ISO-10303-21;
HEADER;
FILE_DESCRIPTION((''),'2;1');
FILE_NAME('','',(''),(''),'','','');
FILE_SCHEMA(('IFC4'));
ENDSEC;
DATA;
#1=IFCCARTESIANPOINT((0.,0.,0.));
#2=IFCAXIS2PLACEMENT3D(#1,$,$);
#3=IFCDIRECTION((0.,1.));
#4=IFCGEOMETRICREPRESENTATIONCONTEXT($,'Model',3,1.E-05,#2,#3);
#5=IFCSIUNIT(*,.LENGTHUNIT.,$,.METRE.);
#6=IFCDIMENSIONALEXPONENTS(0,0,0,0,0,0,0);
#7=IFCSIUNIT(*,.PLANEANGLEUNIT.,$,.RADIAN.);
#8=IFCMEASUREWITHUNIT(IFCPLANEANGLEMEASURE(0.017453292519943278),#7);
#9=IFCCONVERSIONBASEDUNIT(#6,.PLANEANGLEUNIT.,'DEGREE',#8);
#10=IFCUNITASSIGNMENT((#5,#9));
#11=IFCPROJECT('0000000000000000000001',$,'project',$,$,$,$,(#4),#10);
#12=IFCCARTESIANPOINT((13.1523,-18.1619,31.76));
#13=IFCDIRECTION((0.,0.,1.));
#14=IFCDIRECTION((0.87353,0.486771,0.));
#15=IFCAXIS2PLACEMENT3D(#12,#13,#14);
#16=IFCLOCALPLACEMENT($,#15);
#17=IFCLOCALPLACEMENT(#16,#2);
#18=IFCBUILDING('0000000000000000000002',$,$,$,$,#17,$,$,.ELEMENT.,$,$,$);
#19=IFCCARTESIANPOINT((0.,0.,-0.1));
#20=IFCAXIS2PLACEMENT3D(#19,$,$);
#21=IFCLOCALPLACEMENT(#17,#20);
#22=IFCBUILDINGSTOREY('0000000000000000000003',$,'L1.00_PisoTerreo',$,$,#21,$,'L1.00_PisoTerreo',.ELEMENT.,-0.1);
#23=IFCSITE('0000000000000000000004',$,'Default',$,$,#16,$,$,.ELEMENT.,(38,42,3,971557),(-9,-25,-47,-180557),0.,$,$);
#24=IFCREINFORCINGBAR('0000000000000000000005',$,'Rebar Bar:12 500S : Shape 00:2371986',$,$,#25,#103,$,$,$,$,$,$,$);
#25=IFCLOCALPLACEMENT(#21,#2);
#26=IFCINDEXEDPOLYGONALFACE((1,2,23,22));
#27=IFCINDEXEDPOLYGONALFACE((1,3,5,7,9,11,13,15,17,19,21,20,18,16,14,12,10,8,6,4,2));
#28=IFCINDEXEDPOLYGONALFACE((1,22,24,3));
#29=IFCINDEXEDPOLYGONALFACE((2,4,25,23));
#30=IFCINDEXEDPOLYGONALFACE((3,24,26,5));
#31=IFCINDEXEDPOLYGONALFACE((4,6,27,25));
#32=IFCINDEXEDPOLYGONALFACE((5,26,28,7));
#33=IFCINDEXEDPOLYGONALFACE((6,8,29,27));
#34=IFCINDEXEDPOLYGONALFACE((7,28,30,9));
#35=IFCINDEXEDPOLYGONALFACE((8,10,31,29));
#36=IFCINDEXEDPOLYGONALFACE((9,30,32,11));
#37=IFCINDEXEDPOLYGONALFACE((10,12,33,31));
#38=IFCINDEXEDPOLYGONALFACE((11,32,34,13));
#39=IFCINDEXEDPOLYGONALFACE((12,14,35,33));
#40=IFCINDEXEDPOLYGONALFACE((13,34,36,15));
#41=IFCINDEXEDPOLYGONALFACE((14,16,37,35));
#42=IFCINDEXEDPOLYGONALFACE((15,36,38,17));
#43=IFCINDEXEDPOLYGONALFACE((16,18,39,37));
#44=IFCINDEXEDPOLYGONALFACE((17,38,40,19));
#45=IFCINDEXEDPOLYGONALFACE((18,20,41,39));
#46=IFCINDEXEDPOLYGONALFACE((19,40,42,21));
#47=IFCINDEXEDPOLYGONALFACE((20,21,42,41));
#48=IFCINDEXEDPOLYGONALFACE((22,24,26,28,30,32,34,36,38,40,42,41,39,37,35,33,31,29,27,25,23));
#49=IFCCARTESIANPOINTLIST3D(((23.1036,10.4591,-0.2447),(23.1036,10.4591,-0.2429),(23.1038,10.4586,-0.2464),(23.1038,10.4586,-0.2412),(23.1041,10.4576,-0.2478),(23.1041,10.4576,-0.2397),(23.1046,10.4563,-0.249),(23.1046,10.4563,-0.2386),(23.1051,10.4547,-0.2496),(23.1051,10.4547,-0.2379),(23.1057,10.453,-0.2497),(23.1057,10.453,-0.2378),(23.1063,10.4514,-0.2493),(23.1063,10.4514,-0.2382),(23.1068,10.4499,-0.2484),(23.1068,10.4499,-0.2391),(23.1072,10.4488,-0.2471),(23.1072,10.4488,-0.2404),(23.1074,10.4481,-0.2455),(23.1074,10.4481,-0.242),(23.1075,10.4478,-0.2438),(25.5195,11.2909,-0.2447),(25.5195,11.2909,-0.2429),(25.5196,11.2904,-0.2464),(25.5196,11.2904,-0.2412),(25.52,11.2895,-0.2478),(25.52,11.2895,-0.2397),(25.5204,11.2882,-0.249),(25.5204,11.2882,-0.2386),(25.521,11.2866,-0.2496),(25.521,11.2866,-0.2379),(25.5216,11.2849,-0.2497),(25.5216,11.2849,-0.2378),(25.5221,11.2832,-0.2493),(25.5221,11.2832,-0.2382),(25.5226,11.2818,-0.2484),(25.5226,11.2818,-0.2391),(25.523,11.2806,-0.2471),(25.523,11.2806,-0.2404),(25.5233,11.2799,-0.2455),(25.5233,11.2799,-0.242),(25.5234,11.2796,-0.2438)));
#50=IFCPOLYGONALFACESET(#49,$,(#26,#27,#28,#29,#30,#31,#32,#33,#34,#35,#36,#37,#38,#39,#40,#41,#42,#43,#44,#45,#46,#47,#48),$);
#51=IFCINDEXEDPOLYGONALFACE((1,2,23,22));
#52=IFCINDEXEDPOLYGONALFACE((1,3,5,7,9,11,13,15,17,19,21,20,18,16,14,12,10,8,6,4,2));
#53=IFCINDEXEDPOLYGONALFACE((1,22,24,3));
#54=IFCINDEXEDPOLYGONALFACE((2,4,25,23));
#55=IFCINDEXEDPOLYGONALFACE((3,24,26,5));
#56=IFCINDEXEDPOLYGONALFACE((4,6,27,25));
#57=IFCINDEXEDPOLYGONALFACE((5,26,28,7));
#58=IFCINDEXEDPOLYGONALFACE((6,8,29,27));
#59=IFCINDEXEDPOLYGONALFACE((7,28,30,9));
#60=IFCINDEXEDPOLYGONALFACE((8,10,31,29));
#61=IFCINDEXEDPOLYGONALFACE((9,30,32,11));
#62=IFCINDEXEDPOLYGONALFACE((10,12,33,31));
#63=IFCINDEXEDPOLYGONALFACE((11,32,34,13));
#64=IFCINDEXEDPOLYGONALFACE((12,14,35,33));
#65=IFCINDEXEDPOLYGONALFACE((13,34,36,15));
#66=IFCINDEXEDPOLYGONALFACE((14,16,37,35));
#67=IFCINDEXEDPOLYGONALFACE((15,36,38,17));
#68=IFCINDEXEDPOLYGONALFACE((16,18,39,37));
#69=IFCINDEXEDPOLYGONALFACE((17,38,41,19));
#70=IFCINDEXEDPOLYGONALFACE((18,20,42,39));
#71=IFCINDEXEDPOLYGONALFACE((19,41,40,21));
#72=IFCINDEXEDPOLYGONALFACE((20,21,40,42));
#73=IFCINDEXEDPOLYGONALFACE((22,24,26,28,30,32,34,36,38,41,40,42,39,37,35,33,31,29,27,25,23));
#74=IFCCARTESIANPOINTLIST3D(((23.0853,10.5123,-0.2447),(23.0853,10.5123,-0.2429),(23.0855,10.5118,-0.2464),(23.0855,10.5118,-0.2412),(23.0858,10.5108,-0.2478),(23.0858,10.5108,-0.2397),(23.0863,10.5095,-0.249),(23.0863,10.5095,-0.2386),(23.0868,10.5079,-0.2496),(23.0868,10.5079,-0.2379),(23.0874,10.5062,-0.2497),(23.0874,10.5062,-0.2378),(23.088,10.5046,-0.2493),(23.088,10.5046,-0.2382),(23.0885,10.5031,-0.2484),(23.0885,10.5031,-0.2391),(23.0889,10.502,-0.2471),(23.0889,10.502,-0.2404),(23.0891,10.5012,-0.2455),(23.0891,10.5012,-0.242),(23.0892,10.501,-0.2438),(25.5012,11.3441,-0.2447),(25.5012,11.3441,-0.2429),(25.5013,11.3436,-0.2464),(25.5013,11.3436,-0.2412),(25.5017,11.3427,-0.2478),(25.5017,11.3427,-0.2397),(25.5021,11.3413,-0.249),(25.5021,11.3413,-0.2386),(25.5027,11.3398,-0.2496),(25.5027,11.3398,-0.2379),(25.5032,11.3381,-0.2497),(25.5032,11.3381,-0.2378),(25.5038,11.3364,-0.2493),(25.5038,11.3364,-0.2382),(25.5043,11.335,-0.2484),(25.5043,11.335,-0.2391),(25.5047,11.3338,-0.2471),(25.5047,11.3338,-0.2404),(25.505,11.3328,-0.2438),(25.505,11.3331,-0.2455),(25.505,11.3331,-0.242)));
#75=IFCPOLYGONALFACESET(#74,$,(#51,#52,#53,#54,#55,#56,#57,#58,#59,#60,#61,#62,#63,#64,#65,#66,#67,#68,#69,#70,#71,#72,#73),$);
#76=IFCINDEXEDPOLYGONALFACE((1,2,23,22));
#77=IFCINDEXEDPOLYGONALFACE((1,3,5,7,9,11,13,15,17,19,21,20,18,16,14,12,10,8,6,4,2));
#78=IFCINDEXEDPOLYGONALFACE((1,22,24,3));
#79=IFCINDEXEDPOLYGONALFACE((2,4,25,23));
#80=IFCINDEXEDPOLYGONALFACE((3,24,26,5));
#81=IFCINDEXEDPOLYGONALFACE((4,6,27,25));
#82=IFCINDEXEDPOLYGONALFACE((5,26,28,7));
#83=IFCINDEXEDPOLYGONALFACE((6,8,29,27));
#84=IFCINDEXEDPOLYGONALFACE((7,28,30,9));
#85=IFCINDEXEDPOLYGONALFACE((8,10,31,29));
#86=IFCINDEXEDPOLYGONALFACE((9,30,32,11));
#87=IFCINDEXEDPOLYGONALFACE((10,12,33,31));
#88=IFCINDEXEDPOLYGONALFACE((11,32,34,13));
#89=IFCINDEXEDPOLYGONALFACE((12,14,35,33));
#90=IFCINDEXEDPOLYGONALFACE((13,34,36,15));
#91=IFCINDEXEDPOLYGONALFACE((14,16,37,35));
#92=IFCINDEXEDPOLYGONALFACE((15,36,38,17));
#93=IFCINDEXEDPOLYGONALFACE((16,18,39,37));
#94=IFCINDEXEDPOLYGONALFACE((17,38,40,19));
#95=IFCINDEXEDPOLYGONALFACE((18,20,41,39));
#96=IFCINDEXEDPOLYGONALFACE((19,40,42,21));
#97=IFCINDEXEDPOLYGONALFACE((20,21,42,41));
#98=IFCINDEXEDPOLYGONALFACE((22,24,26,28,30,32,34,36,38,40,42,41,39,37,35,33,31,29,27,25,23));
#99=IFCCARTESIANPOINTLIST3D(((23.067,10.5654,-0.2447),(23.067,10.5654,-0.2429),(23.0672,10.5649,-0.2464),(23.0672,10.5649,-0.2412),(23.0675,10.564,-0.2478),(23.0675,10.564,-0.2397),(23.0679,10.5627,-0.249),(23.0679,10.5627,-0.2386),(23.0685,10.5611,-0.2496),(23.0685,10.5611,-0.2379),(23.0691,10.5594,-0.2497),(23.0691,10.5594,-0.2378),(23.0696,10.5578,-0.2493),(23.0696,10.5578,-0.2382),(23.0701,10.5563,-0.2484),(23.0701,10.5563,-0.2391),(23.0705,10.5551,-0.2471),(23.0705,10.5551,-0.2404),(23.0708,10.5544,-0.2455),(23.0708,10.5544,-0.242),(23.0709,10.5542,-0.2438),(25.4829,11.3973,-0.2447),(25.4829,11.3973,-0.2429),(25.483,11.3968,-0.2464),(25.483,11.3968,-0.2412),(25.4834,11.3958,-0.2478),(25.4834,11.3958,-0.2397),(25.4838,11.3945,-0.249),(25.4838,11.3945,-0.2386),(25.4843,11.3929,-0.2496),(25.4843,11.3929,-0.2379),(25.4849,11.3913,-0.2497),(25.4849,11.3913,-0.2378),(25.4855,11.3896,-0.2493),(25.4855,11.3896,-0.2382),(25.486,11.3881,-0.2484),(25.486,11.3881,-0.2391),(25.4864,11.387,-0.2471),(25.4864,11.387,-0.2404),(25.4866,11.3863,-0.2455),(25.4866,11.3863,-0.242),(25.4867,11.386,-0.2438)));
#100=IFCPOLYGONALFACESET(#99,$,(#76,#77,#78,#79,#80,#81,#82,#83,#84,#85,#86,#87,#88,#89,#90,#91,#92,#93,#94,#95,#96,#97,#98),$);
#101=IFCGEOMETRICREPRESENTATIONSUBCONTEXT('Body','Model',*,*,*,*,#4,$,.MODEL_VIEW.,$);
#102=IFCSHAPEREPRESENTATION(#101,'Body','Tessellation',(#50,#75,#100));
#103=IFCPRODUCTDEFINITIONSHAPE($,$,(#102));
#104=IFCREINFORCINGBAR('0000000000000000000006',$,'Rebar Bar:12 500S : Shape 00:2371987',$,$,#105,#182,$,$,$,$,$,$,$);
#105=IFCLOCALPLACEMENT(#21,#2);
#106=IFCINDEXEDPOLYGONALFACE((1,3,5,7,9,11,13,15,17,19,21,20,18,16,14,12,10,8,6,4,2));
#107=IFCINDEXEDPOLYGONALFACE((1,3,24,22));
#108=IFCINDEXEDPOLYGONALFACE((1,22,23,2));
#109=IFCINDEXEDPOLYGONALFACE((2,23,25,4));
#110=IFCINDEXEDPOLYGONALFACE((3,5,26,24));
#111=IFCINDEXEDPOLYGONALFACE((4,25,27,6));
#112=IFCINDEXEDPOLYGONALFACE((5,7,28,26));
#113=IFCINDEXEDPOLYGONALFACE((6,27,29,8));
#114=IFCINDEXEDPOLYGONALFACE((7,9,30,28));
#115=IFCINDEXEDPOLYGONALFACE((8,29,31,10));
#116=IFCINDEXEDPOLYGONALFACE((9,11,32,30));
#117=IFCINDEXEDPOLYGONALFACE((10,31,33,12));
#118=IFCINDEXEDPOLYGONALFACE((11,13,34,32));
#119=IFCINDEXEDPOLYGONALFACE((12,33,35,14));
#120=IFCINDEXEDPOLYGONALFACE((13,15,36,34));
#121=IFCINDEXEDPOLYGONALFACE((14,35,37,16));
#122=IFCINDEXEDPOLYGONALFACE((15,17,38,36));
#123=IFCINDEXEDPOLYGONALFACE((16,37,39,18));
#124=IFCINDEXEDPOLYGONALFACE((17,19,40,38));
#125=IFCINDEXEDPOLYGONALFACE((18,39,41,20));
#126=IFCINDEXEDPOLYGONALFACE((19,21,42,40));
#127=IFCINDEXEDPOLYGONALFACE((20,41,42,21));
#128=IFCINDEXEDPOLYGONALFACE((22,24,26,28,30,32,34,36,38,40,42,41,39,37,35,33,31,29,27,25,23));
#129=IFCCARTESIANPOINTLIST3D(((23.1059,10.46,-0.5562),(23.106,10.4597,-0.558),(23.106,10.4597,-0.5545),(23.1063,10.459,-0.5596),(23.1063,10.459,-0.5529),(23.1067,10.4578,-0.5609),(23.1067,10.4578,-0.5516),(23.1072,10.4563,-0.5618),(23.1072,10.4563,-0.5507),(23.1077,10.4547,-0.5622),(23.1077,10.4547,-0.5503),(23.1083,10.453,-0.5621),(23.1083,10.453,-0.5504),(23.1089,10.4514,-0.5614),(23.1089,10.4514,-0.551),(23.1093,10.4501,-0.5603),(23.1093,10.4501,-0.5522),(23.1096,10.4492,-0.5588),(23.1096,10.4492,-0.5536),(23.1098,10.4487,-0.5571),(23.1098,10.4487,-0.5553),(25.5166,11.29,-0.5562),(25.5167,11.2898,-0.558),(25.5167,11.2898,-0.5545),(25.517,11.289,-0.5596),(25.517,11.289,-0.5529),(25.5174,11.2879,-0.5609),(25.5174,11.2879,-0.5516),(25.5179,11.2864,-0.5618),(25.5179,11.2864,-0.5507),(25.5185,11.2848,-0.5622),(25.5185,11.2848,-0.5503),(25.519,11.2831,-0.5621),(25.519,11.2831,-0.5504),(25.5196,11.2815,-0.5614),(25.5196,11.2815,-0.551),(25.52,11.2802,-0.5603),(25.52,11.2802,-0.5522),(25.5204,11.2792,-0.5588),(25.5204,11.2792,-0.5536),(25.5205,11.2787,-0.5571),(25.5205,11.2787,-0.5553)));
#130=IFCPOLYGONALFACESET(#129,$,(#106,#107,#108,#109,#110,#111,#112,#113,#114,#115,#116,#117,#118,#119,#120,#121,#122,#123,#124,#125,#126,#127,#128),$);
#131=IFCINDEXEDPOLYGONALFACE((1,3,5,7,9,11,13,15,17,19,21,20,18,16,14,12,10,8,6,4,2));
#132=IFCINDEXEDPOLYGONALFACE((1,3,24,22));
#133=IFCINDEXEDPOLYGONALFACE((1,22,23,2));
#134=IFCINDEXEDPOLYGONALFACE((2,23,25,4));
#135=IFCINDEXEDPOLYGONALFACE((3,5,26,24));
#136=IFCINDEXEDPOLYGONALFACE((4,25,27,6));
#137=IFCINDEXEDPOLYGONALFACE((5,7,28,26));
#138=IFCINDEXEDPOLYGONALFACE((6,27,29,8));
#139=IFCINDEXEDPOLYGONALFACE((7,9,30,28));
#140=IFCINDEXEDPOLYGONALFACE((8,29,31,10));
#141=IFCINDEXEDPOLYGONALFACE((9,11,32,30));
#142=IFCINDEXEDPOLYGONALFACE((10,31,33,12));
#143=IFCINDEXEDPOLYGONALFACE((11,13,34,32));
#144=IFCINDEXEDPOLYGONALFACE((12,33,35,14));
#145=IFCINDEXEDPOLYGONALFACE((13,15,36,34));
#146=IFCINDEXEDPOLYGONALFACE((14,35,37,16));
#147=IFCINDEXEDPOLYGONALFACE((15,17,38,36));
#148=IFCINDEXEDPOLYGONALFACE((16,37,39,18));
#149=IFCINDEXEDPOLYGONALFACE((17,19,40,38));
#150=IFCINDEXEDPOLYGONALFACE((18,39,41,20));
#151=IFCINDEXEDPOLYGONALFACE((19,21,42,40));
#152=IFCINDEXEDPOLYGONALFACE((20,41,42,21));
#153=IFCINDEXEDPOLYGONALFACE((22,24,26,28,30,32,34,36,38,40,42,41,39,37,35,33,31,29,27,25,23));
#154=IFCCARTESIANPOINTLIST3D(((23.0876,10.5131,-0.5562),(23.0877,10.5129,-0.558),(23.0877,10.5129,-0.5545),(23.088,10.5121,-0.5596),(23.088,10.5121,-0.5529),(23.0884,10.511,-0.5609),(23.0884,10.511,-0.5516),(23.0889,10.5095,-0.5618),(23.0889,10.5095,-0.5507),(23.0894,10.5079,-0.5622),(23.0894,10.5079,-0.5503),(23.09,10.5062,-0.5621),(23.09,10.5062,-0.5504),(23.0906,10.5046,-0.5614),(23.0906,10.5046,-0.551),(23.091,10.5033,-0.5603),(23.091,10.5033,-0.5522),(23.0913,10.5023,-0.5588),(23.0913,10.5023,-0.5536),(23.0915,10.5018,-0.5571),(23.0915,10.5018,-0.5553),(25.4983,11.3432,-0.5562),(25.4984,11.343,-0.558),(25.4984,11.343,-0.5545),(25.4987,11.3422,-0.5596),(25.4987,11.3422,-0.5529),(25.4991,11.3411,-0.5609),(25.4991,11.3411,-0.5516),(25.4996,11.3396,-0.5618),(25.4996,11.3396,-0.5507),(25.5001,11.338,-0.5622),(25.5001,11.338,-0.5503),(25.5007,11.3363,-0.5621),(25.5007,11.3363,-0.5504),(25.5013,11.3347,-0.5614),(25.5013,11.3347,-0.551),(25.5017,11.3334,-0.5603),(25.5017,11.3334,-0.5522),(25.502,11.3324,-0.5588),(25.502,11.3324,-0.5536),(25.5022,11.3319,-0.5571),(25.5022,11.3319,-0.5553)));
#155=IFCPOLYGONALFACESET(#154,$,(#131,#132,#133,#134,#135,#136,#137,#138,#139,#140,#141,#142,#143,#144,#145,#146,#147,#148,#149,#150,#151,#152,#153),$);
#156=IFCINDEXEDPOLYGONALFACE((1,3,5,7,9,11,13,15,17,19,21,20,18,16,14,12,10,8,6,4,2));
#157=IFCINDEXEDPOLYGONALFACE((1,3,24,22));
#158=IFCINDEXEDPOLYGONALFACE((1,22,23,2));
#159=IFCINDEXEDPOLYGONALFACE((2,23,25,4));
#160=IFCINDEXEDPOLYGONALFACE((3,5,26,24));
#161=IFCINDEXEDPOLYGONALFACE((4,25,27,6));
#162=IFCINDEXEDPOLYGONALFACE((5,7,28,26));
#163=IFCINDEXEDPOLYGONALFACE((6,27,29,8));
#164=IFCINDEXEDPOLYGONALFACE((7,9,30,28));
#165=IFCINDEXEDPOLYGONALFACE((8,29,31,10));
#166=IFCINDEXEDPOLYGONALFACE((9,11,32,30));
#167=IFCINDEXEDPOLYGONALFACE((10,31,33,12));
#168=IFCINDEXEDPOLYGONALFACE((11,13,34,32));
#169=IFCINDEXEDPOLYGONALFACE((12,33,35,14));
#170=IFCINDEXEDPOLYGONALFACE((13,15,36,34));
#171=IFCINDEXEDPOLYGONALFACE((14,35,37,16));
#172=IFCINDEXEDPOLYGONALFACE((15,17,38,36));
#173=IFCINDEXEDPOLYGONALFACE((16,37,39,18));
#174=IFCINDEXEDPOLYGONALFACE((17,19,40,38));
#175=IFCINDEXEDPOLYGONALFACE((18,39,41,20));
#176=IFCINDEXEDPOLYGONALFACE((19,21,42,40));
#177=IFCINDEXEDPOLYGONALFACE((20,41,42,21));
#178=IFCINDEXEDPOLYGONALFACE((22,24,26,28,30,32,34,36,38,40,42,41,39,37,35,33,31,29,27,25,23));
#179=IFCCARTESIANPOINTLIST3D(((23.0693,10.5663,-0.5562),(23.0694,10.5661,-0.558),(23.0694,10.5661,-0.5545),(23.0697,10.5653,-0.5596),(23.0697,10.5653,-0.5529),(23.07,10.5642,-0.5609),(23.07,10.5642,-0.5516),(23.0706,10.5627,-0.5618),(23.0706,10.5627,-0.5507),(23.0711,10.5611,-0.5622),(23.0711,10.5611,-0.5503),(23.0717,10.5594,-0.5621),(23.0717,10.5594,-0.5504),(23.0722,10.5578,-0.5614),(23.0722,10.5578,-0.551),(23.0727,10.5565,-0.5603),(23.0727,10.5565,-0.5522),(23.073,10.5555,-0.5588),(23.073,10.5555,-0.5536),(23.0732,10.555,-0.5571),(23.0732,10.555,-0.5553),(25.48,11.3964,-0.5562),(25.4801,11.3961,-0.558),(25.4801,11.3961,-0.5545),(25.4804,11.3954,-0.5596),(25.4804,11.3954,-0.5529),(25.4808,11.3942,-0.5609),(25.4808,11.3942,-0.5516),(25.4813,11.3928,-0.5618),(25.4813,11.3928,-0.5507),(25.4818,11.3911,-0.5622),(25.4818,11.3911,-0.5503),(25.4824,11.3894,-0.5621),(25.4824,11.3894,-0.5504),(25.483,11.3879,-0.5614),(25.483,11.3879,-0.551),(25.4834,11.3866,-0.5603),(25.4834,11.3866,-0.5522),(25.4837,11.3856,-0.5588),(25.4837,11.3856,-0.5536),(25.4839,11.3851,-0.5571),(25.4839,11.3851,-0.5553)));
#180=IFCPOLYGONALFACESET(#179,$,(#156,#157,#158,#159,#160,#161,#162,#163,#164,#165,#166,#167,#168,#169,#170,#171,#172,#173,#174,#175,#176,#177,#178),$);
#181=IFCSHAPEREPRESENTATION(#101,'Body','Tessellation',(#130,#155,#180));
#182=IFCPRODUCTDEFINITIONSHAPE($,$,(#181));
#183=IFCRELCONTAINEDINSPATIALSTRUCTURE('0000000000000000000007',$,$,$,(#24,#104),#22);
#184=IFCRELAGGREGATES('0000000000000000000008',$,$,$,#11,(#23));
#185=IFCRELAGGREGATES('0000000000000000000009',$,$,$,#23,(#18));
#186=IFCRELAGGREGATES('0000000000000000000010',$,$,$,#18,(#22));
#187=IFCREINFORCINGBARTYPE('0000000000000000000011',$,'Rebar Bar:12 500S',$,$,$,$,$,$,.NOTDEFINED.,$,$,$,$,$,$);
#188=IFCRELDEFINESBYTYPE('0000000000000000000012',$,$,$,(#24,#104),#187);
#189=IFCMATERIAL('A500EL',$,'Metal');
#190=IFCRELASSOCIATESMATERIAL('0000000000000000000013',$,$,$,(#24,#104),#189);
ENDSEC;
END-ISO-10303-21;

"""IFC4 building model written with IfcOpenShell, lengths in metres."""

from ifc_helpers import new_model, entity, si_unit, converted_unit, direction, frame, origin, place, context, subcontext, project, spatial, material, type_object, element, save


model = new_model("IFC4")

# Units and contexts
model_context = context("Model", 3, precision=1e-05, world=origin(), true_north=direction((0.0, 1.0)))
body_context = subcontext(model_context, "Body", "Model", "MODEL_VIEW")
ifc_project = project(units=[si_unit("LENGTHUNIT", "METRE"), converted_unit("PLANEANGLEUNIT", "DEGREE", entity("IfcPlaneAngleMeasure", 0.017453292519943278), si_unit("PLANEANGLEUNIT", "RADIAN"), dimensions=[0, 0, 0, 0, 0, 0, 0])], contexts=[model_context])

# Site, building, storey
site_placement = place(None, frame((13.1523, -18.1619, 31.76), z_axis=(0.0, 0.0, 1.0), x_axis=(0.87353, 0.486771, 0.0)))
site = spatial("IfcSite", under=ifc_project, at=site_placement, Name="Default", CompositionType="ELEMENT", RefLatitude=(38, 42, 3, 971557), RefLongitude=(-9, -25, -47, -180557), RefElevation=0.0)
building_placement = place(site_placement, origin())
building = spatial("IfcBuilding", under=site, at=building_placement, CompositionType="ELEMENT")
storey_placement = place(building_placement, frame((0.0, 0.0, -0.1)))
storey = spatial("IfcBuildingStorey", under=building, at=storey_placement, Name="L1.00_PisoTerreo", LongName="L1.00_PisoTerreo", CompositionType="ELEMENT", Elevation=-0.1)

# Reinforcing bars
ifc_material = material(Name="A500EL", Category="Metal")
reinforcing_bar_type_1 = type_object("IfcReinforcingBarType", Name="Rebar Bar:12 500S", PredefinedType="NOTDEFINED")
reinforcing_bar_1_placement = place(storey_placement, origin())
element("IfcReinforcingBar", 1, at=reinforcing_bar_1_placement, inside=storey, type_object=reinforcing_bar_type_1, material=ifc_material, Name="Rebar Bar:12 500S : Shape 00:2371986", context=body_context, shape_type="AdvancedSweptSolid", body=[
    entity("IfcSweptDiskSolid", entity("IfcIndexedPolyCurve", entity("IfcCartesianPointList3D", [[25.5214, 11.2853, -0.2438], [23.1055, 10.4535, -0.2438]]), None, False), 0.006, None, 0.0, 1.0),
    entity("IfcSweptDiskSolid", entity("IfcIndexedPolyCurve", entity("IfcCartesianPointList3D", [[25.5031, 11.3385, -0.2438], [23.0872, 10.5067, -0.2438]]), None, False), 0.006, None, 0.0, 1.0),
    entity("IfcSweptDiskSolid", entity("IfcIndexedPolyCurve", entity("IfcCartesianPointList3D", [[25.4848, 11.3917, -0.2438], [23.0689, 10.5598, -0.2438]]), None, False), 0.006, None, 0.0, 1.0),
])
reinforcing_bar_2_placement = place(storey_placement, origin())
element("IfcReinforcingBar", 2, at=reinforcing_bar_2_placement, inside=storey, type_object=reinforcing_bar_type_1, material=ifc_material, Name="Rebar Bar:12 500S : Shape 00:2371987", context=body_context, shape_type="AdvancedSweptSolid", body=[
    entity("IfcSweptDiskSolid", entity("IfcIndexedPolyCurve", entity("IfcCartesianPointList3D", [[23.1079, 10.4543, -0.5562], [25.5186, 11.2844, -0.5562]]), None, False), 0.006, None, 0.0, 1.0),
    entity("IfcSweptDiskSolid", entity("IfcIndexedPolyCurve", entity("IfcCartesianPointList3D", [[23.0896, 10.5075, -0.5562], [25.5003, 11.3375, -0.5562]]), None, False), 0.006, None, 0.0, 1.0),
    entity("IfcSweptDiskSolid", entity("IfcIndexedPolyCurve", entity("IfcCartesianPointList3D", [[23.0713, 10.5606, -0.5562], [25.482, 11.3907, -0.5562]]), None, False), 0.006, None, 0.0, 1.0),
])

save(model, "model.ifc")
